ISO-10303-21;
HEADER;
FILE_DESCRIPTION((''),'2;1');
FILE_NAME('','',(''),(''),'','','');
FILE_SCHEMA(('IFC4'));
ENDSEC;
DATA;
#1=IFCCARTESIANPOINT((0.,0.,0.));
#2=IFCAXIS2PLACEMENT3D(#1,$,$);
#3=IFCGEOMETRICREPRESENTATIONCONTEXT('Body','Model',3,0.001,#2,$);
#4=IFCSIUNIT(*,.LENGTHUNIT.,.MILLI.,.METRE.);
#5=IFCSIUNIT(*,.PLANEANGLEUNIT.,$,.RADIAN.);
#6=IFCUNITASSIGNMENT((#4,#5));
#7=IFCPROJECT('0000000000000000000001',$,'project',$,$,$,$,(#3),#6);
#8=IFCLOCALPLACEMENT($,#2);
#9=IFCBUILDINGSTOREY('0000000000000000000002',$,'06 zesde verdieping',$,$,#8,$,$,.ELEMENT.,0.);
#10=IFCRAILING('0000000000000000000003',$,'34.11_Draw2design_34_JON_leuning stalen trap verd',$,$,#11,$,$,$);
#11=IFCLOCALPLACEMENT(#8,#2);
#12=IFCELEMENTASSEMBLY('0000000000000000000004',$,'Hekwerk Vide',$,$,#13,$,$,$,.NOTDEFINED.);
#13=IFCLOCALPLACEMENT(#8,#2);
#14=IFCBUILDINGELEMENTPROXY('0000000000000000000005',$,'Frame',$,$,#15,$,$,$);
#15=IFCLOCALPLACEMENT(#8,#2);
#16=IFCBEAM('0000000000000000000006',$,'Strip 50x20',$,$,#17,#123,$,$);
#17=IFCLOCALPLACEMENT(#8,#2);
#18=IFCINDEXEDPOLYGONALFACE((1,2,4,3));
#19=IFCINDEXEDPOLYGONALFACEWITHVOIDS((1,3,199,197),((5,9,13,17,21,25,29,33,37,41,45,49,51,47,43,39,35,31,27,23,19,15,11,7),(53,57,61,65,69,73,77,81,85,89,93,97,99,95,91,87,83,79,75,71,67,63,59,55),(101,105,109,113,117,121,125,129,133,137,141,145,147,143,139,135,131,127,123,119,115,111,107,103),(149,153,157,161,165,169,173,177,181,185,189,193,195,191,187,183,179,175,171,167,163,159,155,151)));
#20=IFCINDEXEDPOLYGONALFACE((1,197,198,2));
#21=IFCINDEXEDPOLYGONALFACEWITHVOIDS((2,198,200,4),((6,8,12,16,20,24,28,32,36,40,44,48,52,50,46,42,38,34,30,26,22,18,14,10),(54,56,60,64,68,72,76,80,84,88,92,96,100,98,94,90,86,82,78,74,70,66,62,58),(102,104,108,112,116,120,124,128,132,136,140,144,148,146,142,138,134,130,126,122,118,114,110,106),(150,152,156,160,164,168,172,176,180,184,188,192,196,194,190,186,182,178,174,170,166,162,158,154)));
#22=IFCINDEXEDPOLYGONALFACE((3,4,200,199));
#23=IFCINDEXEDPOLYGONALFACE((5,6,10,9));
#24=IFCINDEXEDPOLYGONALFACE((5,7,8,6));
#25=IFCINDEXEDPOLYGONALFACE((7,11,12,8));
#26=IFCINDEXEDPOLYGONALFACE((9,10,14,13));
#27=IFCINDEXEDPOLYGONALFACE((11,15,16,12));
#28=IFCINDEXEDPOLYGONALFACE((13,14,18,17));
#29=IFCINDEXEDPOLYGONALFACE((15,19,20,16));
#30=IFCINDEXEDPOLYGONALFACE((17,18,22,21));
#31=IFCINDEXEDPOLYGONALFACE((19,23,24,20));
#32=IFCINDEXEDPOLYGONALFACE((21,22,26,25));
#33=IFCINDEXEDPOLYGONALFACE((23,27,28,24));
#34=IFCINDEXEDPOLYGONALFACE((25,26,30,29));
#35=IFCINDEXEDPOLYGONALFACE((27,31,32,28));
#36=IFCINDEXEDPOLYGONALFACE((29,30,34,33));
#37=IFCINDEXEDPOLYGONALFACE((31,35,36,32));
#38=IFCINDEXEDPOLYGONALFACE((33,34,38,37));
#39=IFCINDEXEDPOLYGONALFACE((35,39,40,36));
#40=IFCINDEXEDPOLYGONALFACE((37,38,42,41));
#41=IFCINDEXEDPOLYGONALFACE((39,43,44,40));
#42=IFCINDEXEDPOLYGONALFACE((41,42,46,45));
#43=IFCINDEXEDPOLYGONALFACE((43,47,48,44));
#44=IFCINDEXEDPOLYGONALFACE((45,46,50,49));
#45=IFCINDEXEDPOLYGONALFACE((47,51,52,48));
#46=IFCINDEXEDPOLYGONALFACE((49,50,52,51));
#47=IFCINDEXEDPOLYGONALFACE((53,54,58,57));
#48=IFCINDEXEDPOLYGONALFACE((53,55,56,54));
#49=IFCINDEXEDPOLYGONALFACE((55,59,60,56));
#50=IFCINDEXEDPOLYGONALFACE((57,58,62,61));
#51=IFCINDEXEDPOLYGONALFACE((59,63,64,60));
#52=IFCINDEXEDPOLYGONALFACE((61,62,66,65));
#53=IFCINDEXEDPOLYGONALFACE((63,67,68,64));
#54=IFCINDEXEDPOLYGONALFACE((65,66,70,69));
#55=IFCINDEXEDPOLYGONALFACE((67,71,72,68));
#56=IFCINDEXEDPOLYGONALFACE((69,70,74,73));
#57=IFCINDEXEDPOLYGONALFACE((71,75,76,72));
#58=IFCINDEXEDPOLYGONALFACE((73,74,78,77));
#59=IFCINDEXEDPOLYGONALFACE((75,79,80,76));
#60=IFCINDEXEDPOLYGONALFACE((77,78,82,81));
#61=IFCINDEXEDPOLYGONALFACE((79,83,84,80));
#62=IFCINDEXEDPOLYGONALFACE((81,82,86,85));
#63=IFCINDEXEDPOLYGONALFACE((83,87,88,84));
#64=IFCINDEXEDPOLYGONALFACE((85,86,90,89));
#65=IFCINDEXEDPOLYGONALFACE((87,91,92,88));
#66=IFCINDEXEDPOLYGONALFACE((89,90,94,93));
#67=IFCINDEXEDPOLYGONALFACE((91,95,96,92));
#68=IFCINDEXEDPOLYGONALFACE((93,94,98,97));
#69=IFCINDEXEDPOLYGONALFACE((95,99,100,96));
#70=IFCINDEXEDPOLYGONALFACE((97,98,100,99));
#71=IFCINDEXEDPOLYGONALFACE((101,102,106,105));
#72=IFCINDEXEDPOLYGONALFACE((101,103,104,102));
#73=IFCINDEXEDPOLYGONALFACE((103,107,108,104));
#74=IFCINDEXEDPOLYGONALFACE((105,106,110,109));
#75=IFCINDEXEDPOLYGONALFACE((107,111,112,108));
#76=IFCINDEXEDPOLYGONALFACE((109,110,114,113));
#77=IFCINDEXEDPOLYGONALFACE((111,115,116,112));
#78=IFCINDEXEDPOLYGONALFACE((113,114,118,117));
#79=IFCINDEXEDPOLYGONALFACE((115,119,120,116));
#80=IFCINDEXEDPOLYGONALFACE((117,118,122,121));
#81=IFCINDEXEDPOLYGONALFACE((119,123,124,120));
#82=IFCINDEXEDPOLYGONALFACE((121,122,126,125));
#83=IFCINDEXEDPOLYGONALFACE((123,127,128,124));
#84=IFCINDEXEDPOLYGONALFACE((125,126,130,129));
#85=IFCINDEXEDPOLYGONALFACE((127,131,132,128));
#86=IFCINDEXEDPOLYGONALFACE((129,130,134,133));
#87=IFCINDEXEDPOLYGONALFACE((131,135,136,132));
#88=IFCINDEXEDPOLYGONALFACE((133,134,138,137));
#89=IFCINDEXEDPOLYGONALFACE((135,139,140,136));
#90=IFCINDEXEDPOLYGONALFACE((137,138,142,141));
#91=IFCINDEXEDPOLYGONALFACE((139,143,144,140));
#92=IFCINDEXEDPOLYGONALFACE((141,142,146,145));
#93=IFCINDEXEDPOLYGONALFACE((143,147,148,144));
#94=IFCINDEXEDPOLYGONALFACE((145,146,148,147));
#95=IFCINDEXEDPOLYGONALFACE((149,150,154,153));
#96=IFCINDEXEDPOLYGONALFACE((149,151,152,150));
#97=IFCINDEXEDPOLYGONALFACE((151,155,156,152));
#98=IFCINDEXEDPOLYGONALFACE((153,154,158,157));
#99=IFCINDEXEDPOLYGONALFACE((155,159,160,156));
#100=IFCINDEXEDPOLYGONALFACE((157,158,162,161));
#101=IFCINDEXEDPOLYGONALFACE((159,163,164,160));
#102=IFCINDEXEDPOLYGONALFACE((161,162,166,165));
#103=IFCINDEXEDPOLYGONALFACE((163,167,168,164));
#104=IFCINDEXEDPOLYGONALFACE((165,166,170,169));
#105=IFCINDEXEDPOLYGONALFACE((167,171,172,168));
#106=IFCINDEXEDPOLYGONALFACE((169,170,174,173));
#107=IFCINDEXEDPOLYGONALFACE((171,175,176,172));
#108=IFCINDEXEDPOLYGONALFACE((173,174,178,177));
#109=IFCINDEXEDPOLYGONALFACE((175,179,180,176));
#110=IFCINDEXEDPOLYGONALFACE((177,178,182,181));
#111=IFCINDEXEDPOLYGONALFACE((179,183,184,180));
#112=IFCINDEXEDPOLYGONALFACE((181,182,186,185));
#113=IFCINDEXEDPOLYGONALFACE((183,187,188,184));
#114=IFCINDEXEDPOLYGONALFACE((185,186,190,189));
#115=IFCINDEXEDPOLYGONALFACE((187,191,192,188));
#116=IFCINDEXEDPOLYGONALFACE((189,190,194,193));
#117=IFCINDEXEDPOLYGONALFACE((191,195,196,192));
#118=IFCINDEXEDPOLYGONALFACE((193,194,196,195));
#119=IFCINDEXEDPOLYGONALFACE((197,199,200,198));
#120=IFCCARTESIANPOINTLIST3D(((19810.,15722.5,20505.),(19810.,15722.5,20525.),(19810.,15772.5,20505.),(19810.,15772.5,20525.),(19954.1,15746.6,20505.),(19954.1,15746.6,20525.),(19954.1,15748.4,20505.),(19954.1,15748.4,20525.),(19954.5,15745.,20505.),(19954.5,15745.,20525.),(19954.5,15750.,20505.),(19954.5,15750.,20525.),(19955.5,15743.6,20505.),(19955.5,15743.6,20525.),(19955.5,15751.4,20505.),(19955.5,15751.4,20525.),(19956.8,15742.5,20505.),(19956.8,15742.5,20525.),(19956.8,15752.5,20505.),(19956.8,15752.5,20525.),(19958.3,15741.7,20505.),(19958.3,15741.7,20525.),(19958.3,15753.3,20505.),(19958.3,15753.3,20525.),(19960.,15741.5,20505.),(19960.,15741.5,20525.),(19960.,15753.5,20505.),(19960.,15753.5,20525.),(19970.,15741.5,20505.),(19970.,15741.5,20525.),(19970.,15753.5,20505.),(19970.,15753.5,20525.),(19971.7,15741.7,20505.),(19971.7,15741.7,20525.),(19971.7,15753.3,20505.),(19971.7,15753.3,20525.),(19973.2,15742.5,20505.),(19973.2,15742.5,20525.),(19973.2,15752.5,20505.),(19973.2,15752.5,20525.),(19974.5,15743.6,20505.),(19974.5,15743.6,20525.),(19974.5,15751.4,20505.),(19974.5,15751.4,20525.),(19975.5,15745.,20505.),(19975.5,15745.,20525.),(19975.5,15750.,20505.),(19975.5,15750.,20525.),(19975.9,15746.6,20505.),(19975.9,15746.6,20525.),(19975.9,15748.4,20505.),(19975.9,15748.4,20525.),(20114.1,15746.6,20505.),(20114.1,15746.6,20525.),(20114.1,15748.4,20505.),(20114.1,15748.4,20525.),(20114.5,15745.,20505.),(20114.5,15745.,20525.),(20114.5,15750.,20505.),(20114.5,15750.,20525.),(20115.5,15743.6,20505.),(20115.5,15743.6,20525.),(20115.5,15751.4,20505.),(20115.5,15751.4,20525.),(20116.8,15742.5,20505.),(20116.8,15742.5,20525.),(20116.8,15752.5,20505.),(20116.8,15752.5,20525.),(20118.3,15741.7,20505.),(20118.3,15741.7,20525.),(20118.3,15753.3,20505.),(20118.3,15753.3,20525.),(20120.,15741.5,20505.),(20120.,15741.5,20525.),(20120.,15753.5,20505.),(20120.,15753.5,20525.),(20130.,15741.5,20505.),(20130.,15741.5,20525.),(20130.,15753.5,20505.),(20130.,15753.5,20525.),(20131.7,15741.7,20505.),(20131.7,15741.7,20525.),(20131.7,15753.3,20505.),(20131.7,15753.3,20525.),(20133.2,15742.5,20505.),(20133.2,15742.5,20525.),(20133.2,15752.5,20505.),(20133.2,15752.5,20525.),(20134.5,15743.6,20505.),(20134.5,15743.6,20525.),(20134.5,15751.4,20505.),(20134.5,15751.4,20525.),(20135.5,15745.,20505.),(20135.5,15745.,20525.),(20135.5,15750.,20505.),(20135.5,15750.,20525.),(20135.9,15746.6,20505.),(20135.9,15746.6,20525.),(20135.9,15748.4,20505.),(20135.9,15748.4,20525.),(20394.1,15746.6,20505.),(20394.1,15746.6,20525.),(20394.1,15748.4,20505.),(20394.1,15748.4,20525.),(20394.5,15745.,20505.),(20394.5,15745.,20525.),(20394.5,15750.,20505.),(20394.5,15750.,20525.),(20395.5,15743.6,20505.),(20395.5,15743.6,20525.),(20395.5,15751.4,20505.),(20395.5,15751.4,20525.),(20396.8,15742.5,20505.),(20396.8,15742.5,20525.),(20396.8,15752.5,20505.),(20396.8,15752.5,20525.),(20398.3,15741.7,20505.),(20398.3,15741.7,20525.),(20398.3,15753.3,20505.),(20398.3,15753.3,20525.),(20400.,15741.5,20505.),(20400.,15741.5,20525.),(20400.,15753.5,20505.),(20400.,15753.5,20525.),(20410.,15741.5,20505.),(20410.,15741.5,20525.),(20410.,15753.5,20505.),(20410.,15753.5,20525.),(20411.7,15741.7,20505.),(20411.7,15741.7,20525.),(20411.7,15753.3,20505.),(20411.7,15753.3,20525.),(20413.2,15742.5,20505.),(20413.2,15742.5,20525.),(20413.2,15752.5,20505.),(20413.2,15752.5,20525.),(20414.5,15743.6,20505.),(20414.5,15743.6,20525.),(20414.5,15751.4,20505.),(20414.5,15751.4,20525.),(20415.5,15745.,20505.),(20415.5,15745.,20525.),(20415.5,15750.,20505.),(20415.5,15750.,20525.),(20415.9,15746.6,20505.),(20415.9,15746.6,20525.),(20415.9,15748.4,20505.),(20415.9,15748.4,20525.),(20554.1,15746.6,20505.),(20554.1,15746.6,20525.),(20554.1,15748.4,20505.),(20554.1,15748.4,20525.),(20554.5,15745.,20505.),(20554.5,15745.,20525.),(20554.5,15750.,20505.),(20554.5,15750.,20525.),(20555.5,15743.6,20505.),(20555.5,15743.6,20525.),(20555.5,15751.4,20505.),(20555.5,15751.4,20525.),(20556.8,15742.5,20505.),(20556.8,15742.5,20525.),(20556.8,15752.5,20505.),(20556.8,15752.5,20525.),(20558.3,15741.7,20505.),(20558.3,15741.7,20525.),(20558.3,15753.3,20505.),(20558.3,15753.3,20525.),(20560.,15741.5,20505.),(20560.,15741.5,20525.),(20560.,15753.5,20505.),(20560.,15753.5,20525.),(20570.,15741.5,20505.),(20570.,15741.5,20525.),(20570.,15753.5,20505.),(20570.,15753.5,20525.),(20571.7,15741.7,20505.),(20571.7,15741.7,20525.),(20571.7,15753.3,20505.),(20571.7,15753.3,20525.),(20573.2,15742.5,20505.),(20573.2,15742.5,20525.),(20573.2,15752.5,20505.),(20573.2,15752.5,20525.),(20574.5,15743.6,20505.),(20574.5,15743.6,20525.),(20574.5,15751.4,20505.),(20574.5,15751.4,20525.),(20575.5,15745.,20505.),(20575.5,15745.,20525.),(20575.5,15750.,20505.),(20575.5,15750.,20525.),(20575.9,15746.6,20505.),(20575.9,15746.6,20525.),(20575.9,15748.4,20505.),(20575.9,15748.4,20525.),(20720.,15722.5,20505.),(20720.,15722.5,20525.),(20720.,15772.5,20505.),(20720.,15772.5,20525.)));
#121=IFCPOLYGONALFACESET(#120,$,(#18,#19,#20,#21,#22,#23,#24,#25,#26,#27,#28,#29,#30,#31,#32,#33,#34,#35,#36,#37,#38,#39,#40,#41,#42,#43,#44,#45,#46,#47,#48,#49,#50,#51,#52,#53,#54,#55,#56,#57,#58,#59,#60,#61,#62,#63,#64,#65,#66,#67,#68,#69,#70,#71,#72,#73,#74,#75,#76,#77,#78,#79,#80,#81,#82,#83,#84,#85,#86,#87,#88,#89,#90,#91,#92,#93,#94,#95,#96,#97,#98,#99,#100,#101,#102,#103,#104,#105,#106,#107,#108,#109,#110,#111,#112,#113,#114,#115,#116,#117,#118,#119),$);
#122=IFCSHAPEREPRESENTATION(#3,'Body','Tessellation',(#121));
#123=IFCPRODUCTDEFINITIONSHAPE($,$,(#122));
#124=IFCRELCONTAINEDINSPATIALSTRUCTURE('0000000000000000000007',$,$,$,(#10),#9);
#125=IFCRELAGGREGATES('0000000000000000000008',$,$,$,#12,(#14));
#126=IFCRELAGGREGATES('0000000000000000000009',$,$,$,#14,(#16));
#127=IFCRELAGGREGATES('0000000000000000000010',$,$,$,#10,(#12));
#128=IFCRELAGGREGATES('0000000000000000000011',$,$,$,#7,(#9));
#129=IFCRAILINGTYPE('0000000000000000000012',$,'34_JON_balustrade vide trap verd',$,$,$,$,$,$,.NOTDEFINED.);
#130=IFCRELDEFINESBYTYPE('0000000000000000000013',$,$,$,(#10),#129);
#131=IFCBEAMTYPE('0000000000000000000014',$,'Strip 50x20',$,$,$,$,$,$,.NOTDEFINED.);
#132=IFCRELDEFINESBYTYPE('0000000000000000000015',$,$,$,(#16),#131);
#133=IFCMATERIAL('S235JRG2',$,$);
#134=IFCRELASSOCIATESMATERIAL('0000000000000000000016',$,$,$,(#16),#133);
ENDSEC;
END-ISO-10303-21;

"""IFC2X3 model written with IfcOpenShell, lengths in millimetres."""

from ifc_helpers import new_model, si_unit, point, frame, frame_2d, origin, origin_2d, place, context, project, spatial, circle_curve, line_curve, trimmed, segment, composite_curve, rectangle, outline, extrude, source, transform, mapped, material, type_object, element, aggregate, save


model = new_model("IFC2X3")

# Units and contexts
model_context = context("Model", 3, precision=0.001, world=origin(), identifier="Body")
ifc_project = project(units=[si_unit("LENGTHUNIT", "METRE", prefix="MILLI"), si_unit("PLANEANGLEUNIT", "RADIAN")], contexts=[model_context])

# Storey
storey_placement = place(None, origin())
storey = spatial("IfcBuildingStorey", under=ifc_project, at=storey_placement, Name="06 zesde verdieping", CompositionType="ELEMENT", Elevation=0.0)

# Railing, element assembly
railing_type_1 = type_object("IfcRailingType", Name="34_JON_balustrade vide trap verd")
railing_1_placement = place(storey_placement, frame((-24393.0, 36527.0, -28800.0), z_axis=(0.0, 0.0, 1.0), x_axis=(0.0, -1.0, 0.0)))
railing_1 = element("IfcRailing", 1, at=railing_1_placement, inside=storey, type_object=railing_type_1, Name="34.11_Draw2design_34_JON_leuning stalen trap verd")
assembly_placement = place(railing_1_placement, origin())
assembly = element("IfcElementAssembly", 2, at=assembly_placement, Name="Hekwerk Vide", PredefinedType="NOTDEFINED")

# Shared definitions
ifc_material_1 = material(Name="S235JRG2")

# Building element proxy
proxy_1_placement = place(assembly_placement, origin())
proxy_1 = element("IfcBuildingElementProxy", 3, at=proxy_1_placement, Name="Frame")
aggregate(assembly, [proxy_1])

# Beam, openings
beam_type_1 = type_object("IfcBeamType", Name="Strip 50x20")
shared_shape_1 = source(origin(), model_context, "Body", "SweptSolid", [
    extrude(rectangle(XDim=20.0, YDim=50.0, at=origin_2d()), origin(), (0.0, 0.0, -1.0), 910.0),
])
beam_1_placement = place(proxy_1_placement, frame((20779.5, 45113.0, 49315.0), z_axis=(0.0, 1.0, 0.0), x_axis=(0.0, 0.0, 1.0)))
beam_1 = element("IfcBeam", 4, at=beam_1_placement, type_object=beam_type_1, material=ifc_material_1, Name="Strip 50x20", context=model_context, shape_type="MappedRepresentation", body=[
    mapped(shared_shape_1, transform((0.0, 0.0, 0.0), scale=1.0)),
])
opening_1_placement = place(beam_1_placement, frame((10.0, 0.0, -595.0), z_axis=(-1.0, 0.0, 0.0), x_axis=(0.0, 0.0, 1.0)))
element("IfcOpeningElement", 5, at=opening_1_placement, cuts=beam_1, ObjectType="Opening", context=model_context, shape_type="SweptSolid", body=[
    extrude(outline(composite_curve([segment(trimmed(circle_curve(frame_2d((5.0, 0.0), x_axis=(0.0, -1.0)), 6.0), [point((5.0, 6.0))], [point((5.0, -6.0))], False, "CARTESIAN"), True, "CONTINUOUS"), segment(trimmed(line_curve((5.0, -6.0), (-10.0, 0.0), 10.0), [point((5.0, -6.0))], [point((-5.0, -6.0))], True, "CARTESIAN"), True, "CONTINUOUS"), segment(trimmed(circle_curve(frame_2d((-5.0, 0.0), x_axis=(0.0, -1.0)), 6.0), [point((-5.0, -6.0))], [point((-5.0, 6.0))], False, "CARTESIAN"), True, "CONTINUOUS"), segment(trimmed(line_curve((-5.0, 6.0), (10.0, 0.0), 10.0), [point((-5.0, 6.0))], [point((5.0, 6.0))], True, "CARTESIAN"), True, "CONTINUOUS")], self_intersect=False)), origin(), (0.0, 0.0, 1.0), 20.0),
])
opening_2_placement = place(beam_1_placement, frame((10.0, 0.0, -755.0), z_axis=(-1.0, 0.0, 0.0), x_axis=(0.0, 0.0, 1.0)))
element("IfcOpeningElement", 6, at=opening_2_placement, cuts=beam_1, ObjectType="Opening", context=model_context, shape_type="SweptSolid", body=[
    extrude(outline(composite_curve([segment(trimmed(circle_curve(frame_2d((5.0, 0.0), x_axis=(0.0, -1.0)), 6.0), [point((5.0, 6.0))], [point((5.0, -6.0))], False, "CARTESIAN"), True, "CONTINUOUS"), segment(trimmed(line_curve((5.0, -6.0), (-10.0, 0.0), 10.0), [point((5.0, -6.0))], [point((-5.0, -6.0))], True, "CARTESIAN"), True, "CONTINUOUS"), segment(trimmed(circle_curve(frame_2d((-5.0, 0.0), x_axis=(0.0, -1.0)), 6.0), [point((-5.0, -6.0))], [point((-5.0, 6.0))], False, "CARTESIAN"), True, "CONTINUOUS"), segment(trimmed(line_curve((-5.0, 6.0), (10.0, 0.0), 10.0), [point((-5.0, 6.0))], [point((5.0, 6.0))], True, "CARTESIAN"), True, "CONTINUOUS")], self_intersect=False)), origin(), (0.0, 0.0, 1.0), 20.0),
])
opening_3_placement = place(beam_1_placement, frame((10.0, 0.0, -155.0), z_axis=(-1.0, 0.0, 0.0), x_axis=(0.0, 0.0, -1.0)))
element("IfcOpeningElement", 7, at=opening_3_placement, cuts=beam_1, ObjectType="Opening", context=model_context, shape_type="SweptSolid", body=[
    extrude(outline(composite_curve([segment(trimmed(circle_curve(frame_2d((5.0, 0.0), x_axis=(0.0, -1.0)), 6.0), [point((5.0, 6.0))], [point((5.0, -6.0))], False, "CARTESIAN"), True, "CONTINUOUS"), segment(trimmed(line_curve((5.0, -6.0), (-10.0, 0.0), 10.0), [point((5.0, -6.0))], [point((-5.0, -6.0))], True, "CARTESIAN"), True, "CONTINUOUS"), segment(trimmed(circle_curve(frame_2d((-5.0, 0.0), x_axis=(0.0, -1.0)), 6.0), [point((-5.0, -6.0))], [point((-5.0, 6.0))], False, "CARTESIAN"), True, "CONTINUOUS"), segment(trimmed(line_curve((-5.0, 6.0), (10.0, 0.0), 10.0), [point((-5.0, 6.0))], [point((5.0, 6.0))], True, "CARTESIAN"), True, "CONTINUOUS")], self_intersect=False)), origin(), (0.0, 0.0, 1.0), 20.0),
])
opening_4_placement = place(beam_1_placement, frame((10.0, 0.0, -315.0), z_axis=(-1.0, 0.0, 0.0), x_axis=(0.0, 0.0, -1.0)))
element("IfcOpeningElement", 8, at=opening_4_placement, cuts=beam_1, ObjectType="Opening", context=model_context, shape_type="SweptSolid", body=[
    extrude(outline(composite_curve([segment(trimmed(circle_curve(frame_2d((5.0, 0.0), x_axis=(0.0, -1.0)), 6.0), [point((5.0, 6.0))], [point((5.0, -6.0))], False, "CARTESIAN"), True, "CONTINUOUS"), segment(trimmed(line_curve((5.0, -6.0), (-10.0, 0.0), 10.0), [point((5.0, -6.0))], [point((-5.0, -6.0))], True, "CARTESIAN"), True, "CONTINUOUS"), segment(trimmed(circle_curve(frame_2d((-5.0, 0.0), x_axis=(0.0, -1.0)), 6.0), [point((-5.0, -6.0))], [point((-5.0, 6.0))], False, "CARTESIAN"), True, "CONTINUOUS"), segment(trimmed(line_curve((-5.0, 6.0), (10.0, 0.0), 10.0), [point((-5.0, 6.0))], [point((5.0, 6.0))], True, "CARTESIAN"), True, "CONTINUOUS")], self_intersect=False)), origin(), (0.0, 0.0, 1.0), 20.0),
])

aggregate(proxy_1, [beam_1])

aggregate(railing_1, [assembly])

save(model, "model.ifc")
